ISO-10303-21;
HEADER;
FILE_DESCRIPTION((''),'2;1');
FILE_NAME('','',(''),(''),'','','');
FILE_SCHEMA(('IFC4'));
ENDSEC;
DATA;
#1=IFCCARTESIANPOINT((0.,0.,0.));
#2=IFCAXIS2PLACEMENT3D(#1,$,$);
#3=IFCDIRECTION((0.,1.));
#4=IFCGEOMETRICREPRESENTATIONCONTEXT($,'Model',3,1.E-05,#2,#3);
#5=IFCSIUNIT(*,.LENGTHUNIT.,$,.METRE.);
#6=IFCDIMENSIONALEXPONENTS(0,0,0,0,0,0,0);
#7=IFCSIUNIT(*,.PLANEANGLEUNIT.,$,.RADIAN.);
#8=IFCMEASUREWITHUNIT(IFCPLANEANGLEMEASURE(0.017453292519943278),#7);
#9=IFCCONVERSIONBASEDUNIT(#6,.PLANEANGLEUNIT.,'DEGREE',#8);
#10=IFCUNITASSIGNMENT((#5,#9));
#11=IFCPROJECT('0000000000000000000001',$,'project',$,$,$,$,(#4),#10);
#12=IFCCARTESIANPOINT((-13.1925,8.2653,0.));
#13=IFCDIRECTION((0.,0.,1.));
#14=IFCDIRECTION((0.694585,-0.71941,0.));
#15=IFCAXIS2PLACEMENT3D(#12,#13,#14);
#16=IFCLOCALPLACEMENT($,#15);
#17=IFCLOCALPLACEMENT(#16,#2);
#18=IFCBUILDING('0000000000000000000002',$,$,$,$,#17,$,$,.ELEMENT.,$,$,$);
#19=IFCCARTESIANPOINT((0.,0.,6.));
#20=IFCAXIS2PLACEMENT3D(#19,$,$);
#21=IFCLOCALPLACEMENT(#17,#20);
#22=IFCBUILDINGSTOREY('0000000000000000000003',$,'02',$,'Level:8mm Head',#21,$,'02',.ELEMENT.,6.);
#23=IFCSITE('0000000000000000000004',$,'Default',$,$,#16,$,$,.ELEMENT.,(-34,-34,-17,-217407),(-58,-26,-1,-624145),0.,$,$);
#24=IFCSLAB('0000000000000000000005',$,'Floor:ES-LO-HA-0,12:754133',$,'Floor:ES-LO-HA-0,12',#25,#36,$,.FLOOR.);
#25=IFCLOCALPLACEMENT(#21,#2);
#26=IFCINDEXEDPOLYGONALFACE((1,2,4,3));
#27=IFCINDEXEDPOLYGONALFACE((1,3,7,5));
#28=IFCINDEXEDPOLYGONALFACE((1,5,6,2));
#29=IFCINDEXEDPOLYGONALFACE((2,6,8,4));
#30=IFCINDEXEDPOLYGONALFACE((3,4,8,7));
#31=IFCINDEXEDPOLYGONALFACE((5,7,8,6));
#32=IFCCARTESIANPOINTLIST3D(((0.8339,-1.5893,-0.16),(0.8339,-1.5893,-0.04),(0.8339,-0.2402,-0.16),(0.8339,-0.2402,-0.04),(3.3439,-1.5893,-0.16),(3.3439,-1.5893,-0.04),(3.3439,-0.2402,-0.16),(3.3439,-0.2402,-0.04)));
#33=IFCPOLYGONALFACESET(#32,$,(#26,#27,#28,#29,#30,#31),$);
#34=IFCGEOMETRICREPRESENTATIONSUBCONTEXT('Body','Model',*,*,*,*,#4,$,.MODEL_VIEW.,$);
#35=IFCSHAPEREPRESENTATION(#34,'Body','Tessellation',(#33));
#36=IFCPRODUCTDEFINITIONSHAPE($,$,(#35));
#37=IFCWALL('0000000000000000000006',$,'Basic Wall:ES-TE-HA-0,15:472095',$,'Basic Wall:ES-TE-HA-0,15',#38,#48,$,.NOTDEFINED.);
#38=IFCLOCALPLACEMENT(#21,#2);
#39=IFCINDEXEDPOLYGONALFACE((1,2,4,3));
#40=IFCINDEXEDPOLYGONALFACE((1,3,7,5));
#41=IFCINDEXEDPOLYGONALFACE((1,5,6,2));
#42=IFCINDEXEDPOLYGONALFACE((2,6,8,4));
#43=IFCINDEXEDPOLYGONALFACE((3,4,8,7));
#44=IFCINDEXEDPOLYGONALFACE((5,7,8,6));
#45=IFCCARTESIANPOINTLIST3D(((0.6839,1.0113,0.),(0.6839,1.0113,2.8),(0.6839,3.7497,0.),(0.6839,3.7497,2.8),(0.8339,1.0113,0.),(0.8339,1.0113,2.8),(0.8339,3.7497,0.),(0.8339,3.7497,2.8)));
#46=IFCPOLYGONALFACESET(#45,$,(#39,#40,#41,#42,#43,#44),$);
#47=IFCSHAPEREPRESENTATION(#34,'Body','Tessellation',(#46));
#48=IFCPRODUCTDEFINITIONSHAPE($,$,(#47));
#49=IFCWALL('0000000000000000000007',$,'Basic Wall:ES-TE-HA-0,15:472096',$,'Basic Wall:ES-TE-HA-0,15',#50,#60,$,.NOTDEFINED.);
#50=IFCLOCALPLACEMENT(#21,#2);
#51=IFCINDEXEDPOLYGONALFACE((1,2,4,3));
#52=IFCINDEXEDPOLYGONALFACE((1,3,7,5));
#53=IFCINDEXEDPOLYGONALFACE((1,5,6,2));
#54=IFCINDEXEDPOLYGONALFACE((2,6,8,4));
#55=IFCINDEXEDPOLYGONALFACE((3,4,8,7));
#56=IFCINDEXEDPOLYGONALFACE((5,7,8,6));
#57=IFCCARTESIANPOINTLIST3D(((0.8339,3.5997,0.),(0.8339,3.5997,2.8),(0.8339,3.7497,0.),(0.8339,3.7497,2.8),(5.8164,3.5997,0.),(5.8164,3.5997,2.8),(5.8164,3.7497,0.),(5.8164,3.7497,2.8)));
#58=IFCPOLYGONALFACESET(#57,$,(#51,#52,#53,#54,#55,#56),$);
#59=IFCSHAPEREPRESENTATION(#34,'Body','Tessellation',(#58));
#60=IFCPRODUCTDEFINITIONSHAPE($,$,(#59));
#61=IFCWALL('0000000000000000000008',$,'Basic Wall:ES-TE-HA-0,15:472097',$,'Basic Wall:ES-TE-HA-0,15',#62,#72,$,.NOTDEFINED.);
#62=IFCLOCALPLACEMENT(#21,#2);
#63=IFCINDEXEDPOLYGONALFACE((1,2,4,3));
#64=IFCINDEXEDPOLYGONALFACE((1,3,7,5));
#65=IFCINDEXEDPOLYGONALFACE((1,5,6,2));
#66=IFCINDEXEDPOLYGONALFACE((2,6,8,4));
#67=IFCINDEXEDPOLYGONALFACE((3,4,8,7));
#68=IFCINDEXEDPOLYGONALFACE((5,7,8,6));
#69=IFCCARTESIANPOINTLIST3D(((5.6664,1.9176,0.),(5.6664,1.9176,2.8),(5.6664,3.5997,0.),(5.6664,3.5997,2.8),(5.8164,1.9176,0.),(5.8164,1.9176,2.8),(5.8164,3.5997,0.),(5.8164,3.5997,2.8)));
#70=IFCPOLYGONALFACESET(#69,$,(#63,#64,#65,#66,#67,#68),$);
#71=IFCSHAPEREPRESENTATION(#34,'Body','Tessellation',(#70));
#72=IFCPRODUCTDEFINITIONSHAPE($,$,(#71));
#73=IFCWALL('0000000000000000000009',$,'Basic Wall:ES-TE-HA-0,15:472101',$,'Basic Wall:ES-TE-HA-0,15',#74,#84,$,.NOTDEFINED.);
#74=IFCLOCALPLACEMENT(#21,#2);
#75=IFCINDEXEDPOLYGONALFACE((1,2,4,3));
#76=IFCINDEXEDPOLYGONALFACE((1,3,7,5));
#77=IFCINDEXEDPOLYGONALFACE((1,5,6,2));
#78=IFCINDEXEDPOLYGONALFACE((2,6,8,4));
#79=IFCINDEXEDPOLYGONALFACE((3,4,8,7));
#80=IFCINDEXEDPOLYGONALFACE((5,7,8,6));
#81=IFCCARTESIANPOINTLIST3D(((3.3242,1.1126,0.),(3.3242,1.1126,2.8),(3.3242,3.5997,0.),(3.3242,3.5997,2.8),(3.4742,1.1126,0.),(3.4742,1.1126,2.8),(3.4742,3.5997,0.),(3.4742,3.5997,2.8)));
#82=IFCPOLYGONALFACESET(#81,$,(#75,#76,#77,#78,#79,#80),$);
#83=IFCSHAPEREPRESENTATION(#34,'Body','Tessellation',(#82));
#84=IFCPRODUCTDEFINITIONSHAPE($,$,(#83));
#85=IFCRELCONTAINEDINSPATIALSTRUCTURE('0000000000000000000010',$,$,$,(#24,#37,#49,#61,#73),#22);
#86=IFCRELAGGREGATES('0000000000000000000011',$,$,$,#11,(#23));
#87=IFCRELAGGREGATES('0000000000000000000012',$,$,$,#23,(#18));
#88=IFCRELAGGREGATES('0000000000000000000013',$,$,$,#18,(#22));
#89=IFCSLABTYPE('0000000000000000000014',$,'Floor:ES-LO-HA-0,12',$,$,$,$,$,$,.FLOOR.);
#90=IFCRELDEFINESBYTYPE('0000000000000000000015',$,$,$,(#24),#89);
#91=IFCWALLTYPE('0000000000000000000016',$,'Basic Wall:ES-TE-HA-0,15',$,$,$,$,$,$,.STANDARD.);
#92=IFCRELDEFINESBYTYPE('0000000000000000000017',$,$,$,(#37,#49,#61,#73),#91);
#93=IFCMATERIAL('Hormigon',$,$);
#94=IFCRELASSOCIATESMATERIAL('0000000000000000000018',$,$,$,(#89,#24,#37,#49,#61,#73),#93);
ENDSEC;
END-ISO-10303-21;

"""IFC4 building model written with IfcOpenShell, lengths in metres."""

from ifc_helpers import new_model, entity, si_unit, converted_unit, direction, frame, origin, place, context, subcontext, project, spatial, indexed_curve, outline, extrude, material, type_object, element, save


model = new_model("IFC4")

# Units and contexts
model_context = context("Model", 3, precision=1e-05, world=origin(), true_north=direction((0.0, 1.0)))
body_context = subcontext(model_context, "Body", "Model", "MODEL_VIEW")
ifc_project = project(units=[si_unit("LENGTHUNIT", "METRE"), converted_unit("PLANEANGLEUNIT", "DEGREE", entity("IfcPlaneAngleMeasure", 0.017453292519943278), si_unit("PLANEANGLEUNIT", "RADIAN"), dimensions=[0, 0, 0, 0, 0, 0, 0])], contexts=[model_context])

# Site, building, storey
site_placement = place(None, frame((-13.1925, 8.2653, 0.0), z_axis=(0.0, 0.0, 1.0), x_axis=(0.694585, -0.71941, 0.0)))
site = spatial("IfcSite", under=ifc_project, at=site_placement, Name="Default", CompositionType="ELEMENT", RefLatitude=(-34, -34, -17, -217407), RefLongitude=(-58, -26, -1, -624145), RefElevation=0.0)
building_placement = place(site_placement, origin())
building = spatial("IfcBuilding", under=site, at=building_placement, CompositionType="ELEMENT")
storey_placement = place(building_placement, frame((0.0, 0.0, 6.0)))
storey = spatial("IfcBuildingStorey", under=building, at=storey_placement, Name="02", ObjectType="Level:8mm Head", LongName="02", CompositionType="ELEMENT", Elevation=6.0)

# Shared definitions
ifc_material_1 = material(Name="Hormigon")

# Slab
slab_type_1 = type_object("IfcSlabType", Name="Floor:ES-LO-HA-0,12", PredefinedType="FLOOR", material=ifc_material_1)
slab_1_placement = place(storey_placement, origin())
element("IfcSlab", 1, at=slab_1_placement, inside=storey, type_object=slab_type_1, material=ifc_material_1, Name="Floor:ES-LO-HA-0,12:754133", ObjectType="Floor:ES-LO-HA-0,12", PredefinedType="FLOOR", context=body_context, shape_type="SweptSolid", body=[
    extrude(outline(indexed_curve([(-0.6746, -1.255), (0.6746, -1.255), (0.6746, 1.255), (-0.6746, 1.255), (-0.6746, -1.255)], self_intersect=False)), frame((2.0889, -0.9147, -0.04), z_axis=(0.0, 0.0, -1.0), x_axis=(0.0, 1.0, 0.0)), (0.0, 0.0, 1.0), 0.12),
])

# Walls
wall_type = type_object("IfcWallType", Name="Basic Wall:ES-TE-HA-0,15", PredefinedType="STANDARD")
wall_1_placement = place(storey_placement, frame((0.7589, 1.0113, 0.0), z_axis=(0.0, 0.0, 1.0), x_axis=(0.0, 1.0, 0.0)))
element("IfcWall", 2, at=wall_1_placement, inside=storey, type_object=wall_type, material=ifc_material_1, Name="Basic Wall:ES-TE-HA-0,15:472095", ObjectType="Basic Wall:ES-TE-HA-0,15", PredefinedType="NOTDEFINED", context=body_context, shape_type="SweptSolid", body=[
    extrude(outline(indexed_curve([(2.7384, 0.075), (0.0, 0.075), (0.0, -0.075), (2.7384, -0.075), (2.7384, 0.075)], self_intersect=False)), origin(), (0.0, 0.0, 1.0), 2.8),
])
wall_2_placement = place(storey_placement, frame((0.8339, 3.6747, 0.0)))
element("IfcWall", 3, at=wall_2_placement, inside=storey, type_object=wall_type, material=ifc_material_1, Name="Basic Wall:ES-TE-HA-0,15:472096", ObjectType="Basic Wall:ES-TE-HA-0,15", PredefinedType="NOTDEFINED", context=body_context, shape_type="SweptSolid", body=[
    extrude(outline(indexed_curve([(4.9825, 0.075), (0.0, 0.075), (0.0, -0.075), (4.9825, -0.075), (4.9825, 0.075)], self_intersect=False)), origin(), (0.0, 0.0, 1.0), 2.8),
])
wall_3_placement = place(storey_placement, frame((5.7414, 1.9176, 0.0), z_axis=(0.0, 0.0, 1.0), x_axis=(0.0, 1.0, 0.0)))
element("IfcWall", 4, at=wall_3_placement, inside=storey, type_object=wall_type, material=ifc_material_1, Name="Basic Wall:ES-TE-HA-0,15:472097", ObjectType="Basic Wall:ES-TE-HA-0,15", PredefinedType="NOTDEFINED", context=body_context, shape_type="SweptSolid", body=[
    extrude(outline(indexed_curve([(1.682, 0.075), (0.0, 0.075), (0.0, -0.075), (1.682, -0.075), (1.682, 0.075)], self_intersect=False)), origin(), (0.0, 0.0, 1.0), 2.8),
])
wall_4_placement = place(storey_placement, frame((3.3992, 3.5997, 0.0), z_axis=(0.0, 0.0, 1.0), x_axis=(0.0, -1.0, 0.0)))
element("IfcWall", 5, at=wall_4_placement, inside=storey, type_object=wall_type, material=ifc_material_1, Name="Basic Wall:ES-TE-HA-0,15:472101", ObjectType="Basic Wall:ES-TE-HA-0,15", PredefinedType="NOTDEFINED", context=body_context, shape_type="SweptSolid", body=[
    extrude(outline(indexed_curve([(2.487, 0.075), (0.0, 0.075), (0.0, -0.075), (2.487, -0.075), (2.487, 0.075)], self_intersect=False)), origin(), (0.0, 0.0, 1.0), 2.8),
])

save(model, "model.ifc")
